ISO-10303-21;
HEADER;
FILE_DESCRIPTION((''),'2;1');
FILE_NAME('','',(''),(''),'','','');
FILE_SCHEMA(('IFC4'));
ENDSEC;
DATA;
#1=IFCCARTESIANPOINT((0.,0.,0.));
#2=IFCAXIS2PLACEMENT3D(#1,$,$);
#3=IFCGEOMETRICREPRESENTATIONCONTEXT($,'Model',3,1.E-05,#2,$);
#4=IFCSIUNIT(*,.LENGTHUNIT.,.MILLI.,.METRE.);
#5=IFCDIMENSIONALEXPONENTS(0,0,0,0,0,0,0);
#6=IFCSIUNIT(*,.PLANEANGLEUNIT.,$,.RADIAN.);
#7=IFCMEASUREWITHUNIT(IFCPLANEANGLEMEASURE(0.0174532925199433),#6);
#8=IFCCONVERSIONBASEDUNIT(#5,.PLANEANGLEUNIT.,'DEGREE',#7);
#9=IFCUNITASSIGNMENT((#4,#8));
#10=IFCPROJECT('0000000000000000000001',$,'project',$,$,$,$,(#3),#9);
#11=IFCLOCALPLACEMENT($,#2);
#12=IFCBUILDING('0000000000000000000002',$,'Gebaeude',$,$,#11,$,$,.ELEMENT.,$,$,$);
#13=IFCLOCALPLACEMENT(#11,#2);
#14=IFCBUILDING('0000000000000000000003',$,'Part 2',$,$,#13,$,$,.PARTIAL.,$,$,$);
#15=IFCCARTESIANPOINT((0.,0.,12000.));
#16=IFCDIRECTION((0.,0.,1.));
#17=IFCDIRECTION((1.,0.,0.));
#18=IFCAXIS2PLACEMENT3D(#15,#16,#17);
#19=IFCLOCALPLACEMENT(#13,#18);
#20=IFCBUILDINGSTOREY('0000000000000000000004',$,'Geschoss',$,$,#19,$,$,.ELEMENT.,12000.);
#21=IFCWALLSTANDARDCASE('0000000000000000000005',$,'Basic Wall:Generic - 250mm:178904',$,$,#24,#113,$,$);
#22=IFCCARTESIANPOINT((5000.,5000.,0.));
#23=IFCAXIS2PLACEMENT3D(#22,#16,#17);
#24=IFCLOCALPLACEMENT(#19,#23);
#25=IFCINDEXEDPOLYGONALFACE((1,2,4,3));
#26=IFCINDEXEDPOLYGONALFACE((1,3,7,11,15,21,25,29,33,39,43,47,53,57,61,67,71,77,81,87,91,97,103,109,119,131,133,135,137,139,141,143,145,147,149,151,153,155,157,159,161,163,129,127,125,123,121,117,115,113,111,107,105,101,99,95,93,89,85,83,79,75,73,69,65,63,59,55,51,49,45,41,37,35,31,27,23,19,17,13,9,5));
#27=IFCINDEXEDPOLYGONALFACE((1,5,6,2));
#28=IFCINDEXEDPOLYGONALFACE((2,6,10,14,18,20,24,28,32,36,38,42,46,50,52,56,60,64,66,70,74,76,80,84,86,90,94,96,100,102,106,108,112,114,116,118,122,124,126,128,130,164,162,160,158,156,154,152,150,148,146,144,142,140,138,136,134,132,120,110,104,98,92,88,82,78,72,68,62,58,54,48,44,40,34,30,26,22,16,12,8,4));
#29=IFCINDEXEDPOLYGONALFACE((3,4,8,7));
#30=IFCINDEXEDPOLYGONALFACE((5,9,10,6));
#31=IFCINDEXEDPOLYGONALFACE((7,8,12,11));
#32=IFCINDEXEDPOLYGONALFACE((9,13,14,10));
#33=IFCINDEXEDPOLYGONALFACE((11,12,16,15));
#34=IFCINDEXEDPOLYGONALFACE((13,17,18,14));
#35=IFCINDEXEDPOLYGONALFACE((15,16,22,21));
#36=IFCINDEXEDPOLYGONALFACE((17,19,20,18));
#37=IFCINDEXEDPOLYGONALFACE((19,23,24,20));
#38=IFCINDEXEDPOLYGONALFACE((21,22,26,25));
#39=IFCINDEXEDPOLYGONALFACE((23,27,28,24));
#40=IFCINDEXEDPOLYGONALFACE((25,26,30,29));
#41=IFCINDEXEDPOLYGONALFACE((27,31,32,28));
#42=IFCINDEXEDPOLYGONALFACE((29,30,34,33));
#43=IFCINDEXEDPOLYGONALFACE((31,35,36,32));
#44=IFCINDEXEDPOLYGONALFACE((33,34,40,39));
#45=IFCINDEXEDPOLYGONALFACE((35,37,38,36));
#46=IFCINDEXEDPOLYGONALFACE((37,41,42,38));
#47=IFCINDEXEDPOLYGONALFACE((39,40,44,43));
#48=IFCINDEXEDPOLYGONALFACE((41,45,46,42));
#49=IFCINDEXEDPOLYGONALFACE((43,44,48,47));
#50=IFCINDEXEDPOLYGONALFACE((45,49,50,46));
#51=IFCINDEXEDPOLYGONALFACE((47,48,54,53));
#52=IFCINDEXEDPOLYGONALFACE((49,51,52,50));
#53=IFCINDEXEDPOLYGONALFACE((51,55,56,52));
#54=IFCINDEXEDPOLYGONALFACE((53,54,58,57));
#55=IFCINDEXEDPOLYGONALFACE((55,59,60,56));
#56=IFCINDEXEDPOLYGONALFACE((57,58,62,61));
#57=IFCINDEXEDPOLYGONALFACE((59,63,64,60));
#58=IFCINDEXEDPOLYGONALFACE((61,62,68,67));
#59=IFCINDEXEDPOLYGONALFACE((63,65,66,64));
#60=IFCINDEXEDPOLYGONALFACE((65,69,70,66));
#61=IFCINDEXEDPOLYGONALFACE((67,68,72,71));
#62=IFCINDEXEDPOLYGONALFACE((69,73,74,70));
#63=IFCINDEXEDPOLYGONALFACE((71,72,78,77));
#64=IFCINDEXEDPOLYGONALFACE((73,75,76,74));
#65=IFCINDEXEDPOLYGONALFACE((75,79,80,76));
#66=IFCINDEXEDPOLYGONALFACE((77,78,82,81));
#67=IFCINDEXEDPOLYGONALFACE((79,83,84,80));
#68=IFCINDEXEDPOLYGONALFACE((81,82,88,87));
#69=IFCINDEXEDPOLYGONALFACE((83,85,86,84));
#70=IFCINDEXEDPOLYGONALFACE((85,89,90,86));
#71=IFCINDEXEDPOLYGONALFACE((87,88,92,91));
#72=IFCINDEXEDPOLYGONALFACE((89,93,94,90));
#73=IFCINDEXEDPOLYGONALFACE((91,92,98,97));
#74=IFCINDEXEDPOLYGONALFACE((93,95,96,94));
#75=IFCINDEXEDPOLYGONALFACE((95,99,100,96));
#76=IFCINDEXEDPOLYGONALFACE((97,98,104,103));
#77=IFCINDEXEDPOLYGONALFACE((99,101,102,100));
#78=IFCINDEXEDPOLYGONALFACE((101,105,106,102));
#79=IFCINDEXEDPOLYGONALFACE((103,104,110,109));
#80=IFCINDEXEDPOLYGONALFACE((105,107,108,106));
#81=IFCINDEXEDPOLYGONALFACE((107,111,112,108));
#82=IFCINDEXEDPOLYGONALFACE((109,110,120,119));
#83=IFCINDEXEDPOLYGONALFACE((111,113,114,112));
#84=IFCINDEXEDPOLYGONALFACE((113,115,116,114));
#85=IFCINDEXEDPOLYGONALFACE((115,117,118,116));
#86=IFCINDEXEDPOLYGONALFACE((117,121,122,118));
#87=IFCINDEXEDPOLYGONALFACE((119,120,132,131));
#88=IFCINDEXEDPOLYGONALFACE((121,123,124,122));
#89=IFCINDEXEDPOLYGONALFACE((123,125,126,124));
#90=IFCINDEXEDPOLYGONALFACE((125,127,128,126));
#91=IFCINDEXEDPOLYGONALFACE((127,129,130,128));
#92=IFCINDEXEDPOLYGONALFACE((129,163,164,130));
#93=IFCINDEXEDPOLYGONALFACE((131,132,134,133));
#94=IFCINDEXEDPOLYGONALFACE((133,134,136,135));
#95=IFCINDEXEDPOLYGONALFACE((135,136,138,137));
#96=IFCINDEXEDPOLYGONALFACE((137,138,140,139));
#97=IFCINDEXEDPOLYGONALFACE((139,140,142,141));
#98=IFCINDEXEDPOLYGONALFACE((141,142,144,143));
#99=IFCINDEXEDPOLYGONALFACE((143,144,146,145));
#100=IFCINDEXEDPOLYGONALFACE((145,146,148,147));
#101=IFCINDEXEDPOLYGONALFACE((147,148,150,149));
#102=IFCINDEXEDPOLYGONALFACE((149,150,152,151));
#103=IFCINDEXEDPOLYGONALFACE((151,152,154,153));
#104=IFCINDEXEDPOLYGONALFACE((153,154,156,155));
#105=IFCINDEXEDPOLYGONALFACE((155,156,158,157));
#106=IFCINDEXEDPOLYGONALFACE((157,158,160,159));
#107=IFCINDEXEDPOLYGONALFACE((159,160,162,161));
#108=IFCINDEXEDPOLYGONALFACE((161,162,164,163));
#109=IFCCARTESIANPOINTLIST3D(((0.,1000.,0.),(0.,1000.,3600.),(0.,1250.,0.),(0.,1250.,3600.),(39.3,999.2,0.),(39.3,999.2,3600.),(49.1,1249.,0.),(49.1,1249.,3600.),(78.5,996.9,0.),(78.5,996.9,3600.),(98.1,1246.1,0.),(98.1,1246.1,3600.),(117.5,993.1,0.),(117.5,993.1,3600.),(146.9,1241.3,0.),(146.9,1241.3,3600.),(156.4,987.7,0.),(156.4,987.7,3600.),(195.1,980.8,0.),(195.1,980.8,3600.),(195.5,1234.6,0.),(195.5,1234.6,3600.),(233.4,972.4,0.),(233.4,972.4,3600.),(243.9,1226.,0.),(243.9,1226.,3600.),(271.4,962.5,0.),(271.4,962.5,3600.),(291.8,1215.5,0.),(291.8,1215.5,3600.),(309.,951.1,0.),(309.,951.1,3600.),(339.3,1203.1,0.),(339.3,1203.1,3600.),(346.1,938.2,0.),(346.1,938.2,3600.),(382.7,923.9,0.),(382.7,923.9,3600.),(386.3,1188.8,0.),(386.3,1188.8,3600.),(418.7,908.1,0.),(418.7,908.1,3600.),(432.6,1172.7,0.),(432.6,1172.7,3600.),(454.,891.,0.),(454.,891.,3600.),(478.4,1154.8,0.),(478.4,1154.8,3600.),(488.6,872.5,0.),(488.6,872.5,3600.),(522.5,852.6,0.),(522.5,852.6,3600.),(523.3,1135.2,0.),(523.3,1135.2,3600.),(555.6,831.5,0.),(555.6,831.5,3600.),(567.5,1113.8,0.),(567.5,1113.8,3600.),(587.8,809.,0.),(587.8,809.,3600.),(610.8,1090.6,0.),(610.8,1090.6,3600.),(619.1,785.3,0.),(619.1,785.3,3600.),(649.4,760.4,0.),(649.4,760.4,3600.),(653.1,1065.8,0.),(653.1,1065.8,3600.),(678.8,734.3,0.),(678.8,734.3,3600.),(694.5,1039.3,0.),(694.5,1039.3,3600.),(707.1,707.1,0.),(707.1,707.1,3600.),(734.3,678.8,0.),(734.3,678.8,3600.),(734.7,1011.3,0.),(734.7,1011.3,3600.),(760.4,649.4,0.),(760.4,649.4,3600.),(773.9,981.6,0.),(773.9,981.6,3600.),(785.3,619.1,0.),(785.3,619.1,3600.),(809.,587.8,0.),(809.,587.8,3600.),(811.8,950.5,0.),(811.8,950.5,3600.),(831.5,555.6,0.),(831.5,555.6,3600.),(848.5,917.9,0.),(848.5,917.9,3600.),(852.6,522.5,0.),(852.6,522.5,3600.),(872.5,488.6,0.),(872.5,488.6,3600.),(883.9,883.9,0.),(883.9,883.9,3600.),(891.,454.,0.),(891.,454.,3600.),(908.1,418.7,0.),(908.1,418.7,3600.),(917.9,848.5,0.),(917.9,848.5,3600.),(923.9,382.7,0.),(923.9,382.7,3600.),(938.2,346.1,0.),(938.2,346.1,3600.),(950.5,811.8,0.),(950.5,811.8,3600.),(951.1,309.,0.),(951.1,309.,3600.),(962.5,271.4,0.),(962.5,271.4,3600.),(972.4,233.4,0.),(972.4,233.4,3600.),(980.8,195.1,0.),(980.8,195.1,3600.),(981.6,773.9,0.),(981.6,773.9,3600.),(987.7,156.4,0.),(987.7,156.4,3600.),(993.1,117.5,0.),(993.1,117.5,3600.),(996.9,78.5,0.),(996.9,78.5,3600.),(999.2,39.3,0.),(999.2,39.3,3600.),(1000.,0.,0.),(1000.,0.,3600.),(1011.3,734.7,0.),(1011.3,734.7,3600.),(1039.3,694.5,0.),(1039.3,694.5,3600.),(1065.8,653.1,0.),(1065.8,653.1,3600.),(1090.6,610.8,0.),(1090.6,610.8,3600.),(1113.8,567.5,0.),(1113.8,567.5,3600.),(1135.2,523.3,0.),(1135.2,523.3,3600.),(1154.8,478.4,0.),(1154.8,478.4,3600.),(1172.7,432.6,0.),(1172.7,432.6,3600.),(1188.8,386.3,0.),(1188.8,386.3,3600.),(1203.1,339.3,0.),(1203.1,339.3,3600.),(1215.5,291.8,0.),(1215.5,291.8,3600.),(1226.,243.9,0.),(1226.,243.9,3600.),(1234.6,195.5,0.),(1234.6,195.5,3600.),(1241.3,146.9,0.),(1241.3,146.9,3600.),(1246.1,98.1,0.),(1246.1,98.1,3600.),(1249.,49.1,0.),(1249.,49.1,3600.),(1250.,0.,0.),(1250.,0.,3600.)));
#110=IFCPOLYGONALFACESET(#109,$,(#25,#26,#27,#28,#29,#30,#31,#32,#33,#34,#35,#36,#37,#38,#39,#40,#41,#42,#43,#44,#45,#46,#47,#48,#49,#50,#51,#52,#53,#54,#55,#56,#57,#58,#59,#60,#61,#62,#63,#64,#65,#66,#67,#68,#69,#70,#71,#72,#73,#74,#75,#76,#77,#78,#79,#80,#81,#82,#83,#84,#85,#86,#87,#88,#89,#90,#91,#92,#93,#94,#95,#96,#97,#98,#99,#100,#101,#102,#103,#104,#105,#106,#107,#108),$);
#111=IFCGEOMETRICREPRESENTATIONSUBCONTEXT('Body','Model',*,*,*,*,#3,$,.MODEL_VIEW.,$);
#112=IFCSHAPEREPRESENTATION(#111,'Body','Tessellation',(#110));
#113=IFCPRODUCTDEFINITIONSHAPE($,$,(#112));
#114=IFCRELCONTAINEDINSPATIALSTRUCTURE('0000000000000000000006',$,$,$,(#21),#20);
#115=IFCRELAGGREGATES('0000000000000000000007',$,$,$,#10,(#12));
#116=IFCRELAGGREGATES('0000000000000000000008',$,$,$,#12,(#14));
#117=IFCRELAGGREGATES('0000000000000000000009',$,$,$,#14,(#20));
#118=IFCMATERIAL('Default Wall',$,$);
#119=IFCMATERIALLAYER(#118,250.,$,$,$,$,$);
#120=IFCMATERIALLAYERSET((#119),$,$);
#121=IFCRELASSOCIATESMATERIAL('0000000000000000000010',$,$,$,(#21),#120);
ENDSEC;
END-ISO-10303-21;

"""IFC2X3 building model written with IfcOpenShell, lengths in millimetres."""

from ifc_helpers import new_model, entity, si_unit, converted_unit, frame, origin, origin_with_axes, place, context, subcontext, project, spatial, polyline, outline, extrude, material, layer, layer_set, layer_usage, element, save


model = new_model("IFC2X3")

# Units and contexts
model_context = context("Model", 3, precision=1e-05, world=origin())
body_context = subcontext(model_context, "Body", "Model", "MODEL_VIEW")
ifc_project = project(units=[si_unit("LENGTHUNIT", "METRE", prefix="MILLI"), converted_unit("PLANEANGLEUNIT", "DEGREE", entity("IfcPlaneAngleMeasure", 0.0174532925199433), si_unit("PLANEANGLEUNIT", "RADIAN"), dimensions=[0, 0, 0, 0, 0, 0, 0])], contexts=[model_context])

# Buildings, storey
building_1_placement = place(None, origin())
building_1 = spatial("IfcBuilding", under=ifc_project, at=building_1_placement, Name="Gebaeude", CompositionType="ELEMENT")
building_2_placement = place(building_1_placement, origin())
building_2 = spatial("IfcBuilding", under=building_1, at=building_2_placement, Name="Part 2", CompositionType="PARTIAL")
storey_placement = place(building_2_placement, frame((0.0, 0.0, 12000.0), z_axis=(0.0, 0.0, 1.0), x_axis=(1.0, 0.0, 0.0)))
storey = spatial("IfcBuildingStorey", under=building_2, at=storey_placement, Name="Geschoss", CompositionType="ELEMENT", Elevation=12000.0)

# Wall
ifc_material_1 = material(Name="Default Wall")
ifc_layer_1 = layer(ifc_material_1, 250.0)
ifc_layer_set_1 = layer_set([ifc_layer_1])
ifc_layer_usage_1 = layer_usage(ifc_layer_set_1, "AXIS2", "NEGATIVE", 125.0)
wall_1_placement = place(storey_placement, frame((5000.0, 5000.0, 0.0), z_axis=(0.0, 0.0, 1.0), x_axis=(1.0, 0.0, 0.0)))
element("IfcWallStandardCase", 1, at=wall_1_placement, inside=storey, material=ifc_layer_usage_1, Name="Basic Wall:Generic - 250mm:178904", context=body_context, shape_type="SweptSolid", body=[
    extrude(outline(polyline([(0.0, 1250.0), (0.0, 1000.0), (39.3, 999.2), (78.5, 996.9), (117.5, 993.1), (156.4, 987.7), (195.1, 980.8), (233.4, 972.4), (271.4, 962.5), (309.0, 951.1), (346.1, 938.2), (382.7, 923.9), (418.7, 908.1), (454.0, 891.0), (488.6, 872.5), (522.5, 852.6), (555.6, 831.5), (587.8, 809.0), (619.1, 785.3), (649.4, 760.4), (678.8, 734.3), (707.1, 707.1), (734.3, 678.8), (760.4, 649.4), (785.3, 619.1), (809.0, 587.8), (831.5, 555.6), (852.6, 522.5), (872.5, 488.6), (891.0, 454.0), (908.1, 418.7), (923.9, 382.7), (938.2, 346.1), (951.1, 309.0), (962.5, 271.4), (972.4, 233.4), (980.8, 195.1), (987.7, 156.4), (993.1, 117.5), (996.9, 78.5), (999.2, 39.3), (1000.0, 0.0), (1250.0, 0.0), (1249.0, 49.1), (1246.1, 98.1), (1241.3, 146.9), (1234.6, 195.5), (1226.0, 243.9), (1215.5, 291.8), (1203.1, 339.3), (1188.8, 386.3), (1172.7, 432.6), (1154.8, 478.4), (1135.2, 523.3), (1113.8, 567.5), (1090.6, 610.8), (1065.8, 653.1), (1039.3, 694.5), (1011.3, 734.7), (981.6, 773.9), (950.5, 811.8), (917.9, 848.5), (883.9, 883.9), (848.5, 917.9), (811.8, 950.5), (773.9, 981.6), (734.7, 1011.3), (694.5, 1039.3), (653.1, 1065.8), (610.8, 1090.6), (567.5, 1113.8), (523.3, 1135.2), (478.4, 1154.8), (432.6, 1172.7), (386.3, 1188.8), (339.3, 1203.1), (291.8, 1215.5), (243.9, 1226.0), (195.5, 1234.6), (146.9, 1241.3), (98.1, 1246.1), (49.1, 1249.0), (0.0, 1250.0)])), origin_with_axes(), (0.0, 0.0, 1.0), 3600.0),
])

save(model, "model.ifc")
